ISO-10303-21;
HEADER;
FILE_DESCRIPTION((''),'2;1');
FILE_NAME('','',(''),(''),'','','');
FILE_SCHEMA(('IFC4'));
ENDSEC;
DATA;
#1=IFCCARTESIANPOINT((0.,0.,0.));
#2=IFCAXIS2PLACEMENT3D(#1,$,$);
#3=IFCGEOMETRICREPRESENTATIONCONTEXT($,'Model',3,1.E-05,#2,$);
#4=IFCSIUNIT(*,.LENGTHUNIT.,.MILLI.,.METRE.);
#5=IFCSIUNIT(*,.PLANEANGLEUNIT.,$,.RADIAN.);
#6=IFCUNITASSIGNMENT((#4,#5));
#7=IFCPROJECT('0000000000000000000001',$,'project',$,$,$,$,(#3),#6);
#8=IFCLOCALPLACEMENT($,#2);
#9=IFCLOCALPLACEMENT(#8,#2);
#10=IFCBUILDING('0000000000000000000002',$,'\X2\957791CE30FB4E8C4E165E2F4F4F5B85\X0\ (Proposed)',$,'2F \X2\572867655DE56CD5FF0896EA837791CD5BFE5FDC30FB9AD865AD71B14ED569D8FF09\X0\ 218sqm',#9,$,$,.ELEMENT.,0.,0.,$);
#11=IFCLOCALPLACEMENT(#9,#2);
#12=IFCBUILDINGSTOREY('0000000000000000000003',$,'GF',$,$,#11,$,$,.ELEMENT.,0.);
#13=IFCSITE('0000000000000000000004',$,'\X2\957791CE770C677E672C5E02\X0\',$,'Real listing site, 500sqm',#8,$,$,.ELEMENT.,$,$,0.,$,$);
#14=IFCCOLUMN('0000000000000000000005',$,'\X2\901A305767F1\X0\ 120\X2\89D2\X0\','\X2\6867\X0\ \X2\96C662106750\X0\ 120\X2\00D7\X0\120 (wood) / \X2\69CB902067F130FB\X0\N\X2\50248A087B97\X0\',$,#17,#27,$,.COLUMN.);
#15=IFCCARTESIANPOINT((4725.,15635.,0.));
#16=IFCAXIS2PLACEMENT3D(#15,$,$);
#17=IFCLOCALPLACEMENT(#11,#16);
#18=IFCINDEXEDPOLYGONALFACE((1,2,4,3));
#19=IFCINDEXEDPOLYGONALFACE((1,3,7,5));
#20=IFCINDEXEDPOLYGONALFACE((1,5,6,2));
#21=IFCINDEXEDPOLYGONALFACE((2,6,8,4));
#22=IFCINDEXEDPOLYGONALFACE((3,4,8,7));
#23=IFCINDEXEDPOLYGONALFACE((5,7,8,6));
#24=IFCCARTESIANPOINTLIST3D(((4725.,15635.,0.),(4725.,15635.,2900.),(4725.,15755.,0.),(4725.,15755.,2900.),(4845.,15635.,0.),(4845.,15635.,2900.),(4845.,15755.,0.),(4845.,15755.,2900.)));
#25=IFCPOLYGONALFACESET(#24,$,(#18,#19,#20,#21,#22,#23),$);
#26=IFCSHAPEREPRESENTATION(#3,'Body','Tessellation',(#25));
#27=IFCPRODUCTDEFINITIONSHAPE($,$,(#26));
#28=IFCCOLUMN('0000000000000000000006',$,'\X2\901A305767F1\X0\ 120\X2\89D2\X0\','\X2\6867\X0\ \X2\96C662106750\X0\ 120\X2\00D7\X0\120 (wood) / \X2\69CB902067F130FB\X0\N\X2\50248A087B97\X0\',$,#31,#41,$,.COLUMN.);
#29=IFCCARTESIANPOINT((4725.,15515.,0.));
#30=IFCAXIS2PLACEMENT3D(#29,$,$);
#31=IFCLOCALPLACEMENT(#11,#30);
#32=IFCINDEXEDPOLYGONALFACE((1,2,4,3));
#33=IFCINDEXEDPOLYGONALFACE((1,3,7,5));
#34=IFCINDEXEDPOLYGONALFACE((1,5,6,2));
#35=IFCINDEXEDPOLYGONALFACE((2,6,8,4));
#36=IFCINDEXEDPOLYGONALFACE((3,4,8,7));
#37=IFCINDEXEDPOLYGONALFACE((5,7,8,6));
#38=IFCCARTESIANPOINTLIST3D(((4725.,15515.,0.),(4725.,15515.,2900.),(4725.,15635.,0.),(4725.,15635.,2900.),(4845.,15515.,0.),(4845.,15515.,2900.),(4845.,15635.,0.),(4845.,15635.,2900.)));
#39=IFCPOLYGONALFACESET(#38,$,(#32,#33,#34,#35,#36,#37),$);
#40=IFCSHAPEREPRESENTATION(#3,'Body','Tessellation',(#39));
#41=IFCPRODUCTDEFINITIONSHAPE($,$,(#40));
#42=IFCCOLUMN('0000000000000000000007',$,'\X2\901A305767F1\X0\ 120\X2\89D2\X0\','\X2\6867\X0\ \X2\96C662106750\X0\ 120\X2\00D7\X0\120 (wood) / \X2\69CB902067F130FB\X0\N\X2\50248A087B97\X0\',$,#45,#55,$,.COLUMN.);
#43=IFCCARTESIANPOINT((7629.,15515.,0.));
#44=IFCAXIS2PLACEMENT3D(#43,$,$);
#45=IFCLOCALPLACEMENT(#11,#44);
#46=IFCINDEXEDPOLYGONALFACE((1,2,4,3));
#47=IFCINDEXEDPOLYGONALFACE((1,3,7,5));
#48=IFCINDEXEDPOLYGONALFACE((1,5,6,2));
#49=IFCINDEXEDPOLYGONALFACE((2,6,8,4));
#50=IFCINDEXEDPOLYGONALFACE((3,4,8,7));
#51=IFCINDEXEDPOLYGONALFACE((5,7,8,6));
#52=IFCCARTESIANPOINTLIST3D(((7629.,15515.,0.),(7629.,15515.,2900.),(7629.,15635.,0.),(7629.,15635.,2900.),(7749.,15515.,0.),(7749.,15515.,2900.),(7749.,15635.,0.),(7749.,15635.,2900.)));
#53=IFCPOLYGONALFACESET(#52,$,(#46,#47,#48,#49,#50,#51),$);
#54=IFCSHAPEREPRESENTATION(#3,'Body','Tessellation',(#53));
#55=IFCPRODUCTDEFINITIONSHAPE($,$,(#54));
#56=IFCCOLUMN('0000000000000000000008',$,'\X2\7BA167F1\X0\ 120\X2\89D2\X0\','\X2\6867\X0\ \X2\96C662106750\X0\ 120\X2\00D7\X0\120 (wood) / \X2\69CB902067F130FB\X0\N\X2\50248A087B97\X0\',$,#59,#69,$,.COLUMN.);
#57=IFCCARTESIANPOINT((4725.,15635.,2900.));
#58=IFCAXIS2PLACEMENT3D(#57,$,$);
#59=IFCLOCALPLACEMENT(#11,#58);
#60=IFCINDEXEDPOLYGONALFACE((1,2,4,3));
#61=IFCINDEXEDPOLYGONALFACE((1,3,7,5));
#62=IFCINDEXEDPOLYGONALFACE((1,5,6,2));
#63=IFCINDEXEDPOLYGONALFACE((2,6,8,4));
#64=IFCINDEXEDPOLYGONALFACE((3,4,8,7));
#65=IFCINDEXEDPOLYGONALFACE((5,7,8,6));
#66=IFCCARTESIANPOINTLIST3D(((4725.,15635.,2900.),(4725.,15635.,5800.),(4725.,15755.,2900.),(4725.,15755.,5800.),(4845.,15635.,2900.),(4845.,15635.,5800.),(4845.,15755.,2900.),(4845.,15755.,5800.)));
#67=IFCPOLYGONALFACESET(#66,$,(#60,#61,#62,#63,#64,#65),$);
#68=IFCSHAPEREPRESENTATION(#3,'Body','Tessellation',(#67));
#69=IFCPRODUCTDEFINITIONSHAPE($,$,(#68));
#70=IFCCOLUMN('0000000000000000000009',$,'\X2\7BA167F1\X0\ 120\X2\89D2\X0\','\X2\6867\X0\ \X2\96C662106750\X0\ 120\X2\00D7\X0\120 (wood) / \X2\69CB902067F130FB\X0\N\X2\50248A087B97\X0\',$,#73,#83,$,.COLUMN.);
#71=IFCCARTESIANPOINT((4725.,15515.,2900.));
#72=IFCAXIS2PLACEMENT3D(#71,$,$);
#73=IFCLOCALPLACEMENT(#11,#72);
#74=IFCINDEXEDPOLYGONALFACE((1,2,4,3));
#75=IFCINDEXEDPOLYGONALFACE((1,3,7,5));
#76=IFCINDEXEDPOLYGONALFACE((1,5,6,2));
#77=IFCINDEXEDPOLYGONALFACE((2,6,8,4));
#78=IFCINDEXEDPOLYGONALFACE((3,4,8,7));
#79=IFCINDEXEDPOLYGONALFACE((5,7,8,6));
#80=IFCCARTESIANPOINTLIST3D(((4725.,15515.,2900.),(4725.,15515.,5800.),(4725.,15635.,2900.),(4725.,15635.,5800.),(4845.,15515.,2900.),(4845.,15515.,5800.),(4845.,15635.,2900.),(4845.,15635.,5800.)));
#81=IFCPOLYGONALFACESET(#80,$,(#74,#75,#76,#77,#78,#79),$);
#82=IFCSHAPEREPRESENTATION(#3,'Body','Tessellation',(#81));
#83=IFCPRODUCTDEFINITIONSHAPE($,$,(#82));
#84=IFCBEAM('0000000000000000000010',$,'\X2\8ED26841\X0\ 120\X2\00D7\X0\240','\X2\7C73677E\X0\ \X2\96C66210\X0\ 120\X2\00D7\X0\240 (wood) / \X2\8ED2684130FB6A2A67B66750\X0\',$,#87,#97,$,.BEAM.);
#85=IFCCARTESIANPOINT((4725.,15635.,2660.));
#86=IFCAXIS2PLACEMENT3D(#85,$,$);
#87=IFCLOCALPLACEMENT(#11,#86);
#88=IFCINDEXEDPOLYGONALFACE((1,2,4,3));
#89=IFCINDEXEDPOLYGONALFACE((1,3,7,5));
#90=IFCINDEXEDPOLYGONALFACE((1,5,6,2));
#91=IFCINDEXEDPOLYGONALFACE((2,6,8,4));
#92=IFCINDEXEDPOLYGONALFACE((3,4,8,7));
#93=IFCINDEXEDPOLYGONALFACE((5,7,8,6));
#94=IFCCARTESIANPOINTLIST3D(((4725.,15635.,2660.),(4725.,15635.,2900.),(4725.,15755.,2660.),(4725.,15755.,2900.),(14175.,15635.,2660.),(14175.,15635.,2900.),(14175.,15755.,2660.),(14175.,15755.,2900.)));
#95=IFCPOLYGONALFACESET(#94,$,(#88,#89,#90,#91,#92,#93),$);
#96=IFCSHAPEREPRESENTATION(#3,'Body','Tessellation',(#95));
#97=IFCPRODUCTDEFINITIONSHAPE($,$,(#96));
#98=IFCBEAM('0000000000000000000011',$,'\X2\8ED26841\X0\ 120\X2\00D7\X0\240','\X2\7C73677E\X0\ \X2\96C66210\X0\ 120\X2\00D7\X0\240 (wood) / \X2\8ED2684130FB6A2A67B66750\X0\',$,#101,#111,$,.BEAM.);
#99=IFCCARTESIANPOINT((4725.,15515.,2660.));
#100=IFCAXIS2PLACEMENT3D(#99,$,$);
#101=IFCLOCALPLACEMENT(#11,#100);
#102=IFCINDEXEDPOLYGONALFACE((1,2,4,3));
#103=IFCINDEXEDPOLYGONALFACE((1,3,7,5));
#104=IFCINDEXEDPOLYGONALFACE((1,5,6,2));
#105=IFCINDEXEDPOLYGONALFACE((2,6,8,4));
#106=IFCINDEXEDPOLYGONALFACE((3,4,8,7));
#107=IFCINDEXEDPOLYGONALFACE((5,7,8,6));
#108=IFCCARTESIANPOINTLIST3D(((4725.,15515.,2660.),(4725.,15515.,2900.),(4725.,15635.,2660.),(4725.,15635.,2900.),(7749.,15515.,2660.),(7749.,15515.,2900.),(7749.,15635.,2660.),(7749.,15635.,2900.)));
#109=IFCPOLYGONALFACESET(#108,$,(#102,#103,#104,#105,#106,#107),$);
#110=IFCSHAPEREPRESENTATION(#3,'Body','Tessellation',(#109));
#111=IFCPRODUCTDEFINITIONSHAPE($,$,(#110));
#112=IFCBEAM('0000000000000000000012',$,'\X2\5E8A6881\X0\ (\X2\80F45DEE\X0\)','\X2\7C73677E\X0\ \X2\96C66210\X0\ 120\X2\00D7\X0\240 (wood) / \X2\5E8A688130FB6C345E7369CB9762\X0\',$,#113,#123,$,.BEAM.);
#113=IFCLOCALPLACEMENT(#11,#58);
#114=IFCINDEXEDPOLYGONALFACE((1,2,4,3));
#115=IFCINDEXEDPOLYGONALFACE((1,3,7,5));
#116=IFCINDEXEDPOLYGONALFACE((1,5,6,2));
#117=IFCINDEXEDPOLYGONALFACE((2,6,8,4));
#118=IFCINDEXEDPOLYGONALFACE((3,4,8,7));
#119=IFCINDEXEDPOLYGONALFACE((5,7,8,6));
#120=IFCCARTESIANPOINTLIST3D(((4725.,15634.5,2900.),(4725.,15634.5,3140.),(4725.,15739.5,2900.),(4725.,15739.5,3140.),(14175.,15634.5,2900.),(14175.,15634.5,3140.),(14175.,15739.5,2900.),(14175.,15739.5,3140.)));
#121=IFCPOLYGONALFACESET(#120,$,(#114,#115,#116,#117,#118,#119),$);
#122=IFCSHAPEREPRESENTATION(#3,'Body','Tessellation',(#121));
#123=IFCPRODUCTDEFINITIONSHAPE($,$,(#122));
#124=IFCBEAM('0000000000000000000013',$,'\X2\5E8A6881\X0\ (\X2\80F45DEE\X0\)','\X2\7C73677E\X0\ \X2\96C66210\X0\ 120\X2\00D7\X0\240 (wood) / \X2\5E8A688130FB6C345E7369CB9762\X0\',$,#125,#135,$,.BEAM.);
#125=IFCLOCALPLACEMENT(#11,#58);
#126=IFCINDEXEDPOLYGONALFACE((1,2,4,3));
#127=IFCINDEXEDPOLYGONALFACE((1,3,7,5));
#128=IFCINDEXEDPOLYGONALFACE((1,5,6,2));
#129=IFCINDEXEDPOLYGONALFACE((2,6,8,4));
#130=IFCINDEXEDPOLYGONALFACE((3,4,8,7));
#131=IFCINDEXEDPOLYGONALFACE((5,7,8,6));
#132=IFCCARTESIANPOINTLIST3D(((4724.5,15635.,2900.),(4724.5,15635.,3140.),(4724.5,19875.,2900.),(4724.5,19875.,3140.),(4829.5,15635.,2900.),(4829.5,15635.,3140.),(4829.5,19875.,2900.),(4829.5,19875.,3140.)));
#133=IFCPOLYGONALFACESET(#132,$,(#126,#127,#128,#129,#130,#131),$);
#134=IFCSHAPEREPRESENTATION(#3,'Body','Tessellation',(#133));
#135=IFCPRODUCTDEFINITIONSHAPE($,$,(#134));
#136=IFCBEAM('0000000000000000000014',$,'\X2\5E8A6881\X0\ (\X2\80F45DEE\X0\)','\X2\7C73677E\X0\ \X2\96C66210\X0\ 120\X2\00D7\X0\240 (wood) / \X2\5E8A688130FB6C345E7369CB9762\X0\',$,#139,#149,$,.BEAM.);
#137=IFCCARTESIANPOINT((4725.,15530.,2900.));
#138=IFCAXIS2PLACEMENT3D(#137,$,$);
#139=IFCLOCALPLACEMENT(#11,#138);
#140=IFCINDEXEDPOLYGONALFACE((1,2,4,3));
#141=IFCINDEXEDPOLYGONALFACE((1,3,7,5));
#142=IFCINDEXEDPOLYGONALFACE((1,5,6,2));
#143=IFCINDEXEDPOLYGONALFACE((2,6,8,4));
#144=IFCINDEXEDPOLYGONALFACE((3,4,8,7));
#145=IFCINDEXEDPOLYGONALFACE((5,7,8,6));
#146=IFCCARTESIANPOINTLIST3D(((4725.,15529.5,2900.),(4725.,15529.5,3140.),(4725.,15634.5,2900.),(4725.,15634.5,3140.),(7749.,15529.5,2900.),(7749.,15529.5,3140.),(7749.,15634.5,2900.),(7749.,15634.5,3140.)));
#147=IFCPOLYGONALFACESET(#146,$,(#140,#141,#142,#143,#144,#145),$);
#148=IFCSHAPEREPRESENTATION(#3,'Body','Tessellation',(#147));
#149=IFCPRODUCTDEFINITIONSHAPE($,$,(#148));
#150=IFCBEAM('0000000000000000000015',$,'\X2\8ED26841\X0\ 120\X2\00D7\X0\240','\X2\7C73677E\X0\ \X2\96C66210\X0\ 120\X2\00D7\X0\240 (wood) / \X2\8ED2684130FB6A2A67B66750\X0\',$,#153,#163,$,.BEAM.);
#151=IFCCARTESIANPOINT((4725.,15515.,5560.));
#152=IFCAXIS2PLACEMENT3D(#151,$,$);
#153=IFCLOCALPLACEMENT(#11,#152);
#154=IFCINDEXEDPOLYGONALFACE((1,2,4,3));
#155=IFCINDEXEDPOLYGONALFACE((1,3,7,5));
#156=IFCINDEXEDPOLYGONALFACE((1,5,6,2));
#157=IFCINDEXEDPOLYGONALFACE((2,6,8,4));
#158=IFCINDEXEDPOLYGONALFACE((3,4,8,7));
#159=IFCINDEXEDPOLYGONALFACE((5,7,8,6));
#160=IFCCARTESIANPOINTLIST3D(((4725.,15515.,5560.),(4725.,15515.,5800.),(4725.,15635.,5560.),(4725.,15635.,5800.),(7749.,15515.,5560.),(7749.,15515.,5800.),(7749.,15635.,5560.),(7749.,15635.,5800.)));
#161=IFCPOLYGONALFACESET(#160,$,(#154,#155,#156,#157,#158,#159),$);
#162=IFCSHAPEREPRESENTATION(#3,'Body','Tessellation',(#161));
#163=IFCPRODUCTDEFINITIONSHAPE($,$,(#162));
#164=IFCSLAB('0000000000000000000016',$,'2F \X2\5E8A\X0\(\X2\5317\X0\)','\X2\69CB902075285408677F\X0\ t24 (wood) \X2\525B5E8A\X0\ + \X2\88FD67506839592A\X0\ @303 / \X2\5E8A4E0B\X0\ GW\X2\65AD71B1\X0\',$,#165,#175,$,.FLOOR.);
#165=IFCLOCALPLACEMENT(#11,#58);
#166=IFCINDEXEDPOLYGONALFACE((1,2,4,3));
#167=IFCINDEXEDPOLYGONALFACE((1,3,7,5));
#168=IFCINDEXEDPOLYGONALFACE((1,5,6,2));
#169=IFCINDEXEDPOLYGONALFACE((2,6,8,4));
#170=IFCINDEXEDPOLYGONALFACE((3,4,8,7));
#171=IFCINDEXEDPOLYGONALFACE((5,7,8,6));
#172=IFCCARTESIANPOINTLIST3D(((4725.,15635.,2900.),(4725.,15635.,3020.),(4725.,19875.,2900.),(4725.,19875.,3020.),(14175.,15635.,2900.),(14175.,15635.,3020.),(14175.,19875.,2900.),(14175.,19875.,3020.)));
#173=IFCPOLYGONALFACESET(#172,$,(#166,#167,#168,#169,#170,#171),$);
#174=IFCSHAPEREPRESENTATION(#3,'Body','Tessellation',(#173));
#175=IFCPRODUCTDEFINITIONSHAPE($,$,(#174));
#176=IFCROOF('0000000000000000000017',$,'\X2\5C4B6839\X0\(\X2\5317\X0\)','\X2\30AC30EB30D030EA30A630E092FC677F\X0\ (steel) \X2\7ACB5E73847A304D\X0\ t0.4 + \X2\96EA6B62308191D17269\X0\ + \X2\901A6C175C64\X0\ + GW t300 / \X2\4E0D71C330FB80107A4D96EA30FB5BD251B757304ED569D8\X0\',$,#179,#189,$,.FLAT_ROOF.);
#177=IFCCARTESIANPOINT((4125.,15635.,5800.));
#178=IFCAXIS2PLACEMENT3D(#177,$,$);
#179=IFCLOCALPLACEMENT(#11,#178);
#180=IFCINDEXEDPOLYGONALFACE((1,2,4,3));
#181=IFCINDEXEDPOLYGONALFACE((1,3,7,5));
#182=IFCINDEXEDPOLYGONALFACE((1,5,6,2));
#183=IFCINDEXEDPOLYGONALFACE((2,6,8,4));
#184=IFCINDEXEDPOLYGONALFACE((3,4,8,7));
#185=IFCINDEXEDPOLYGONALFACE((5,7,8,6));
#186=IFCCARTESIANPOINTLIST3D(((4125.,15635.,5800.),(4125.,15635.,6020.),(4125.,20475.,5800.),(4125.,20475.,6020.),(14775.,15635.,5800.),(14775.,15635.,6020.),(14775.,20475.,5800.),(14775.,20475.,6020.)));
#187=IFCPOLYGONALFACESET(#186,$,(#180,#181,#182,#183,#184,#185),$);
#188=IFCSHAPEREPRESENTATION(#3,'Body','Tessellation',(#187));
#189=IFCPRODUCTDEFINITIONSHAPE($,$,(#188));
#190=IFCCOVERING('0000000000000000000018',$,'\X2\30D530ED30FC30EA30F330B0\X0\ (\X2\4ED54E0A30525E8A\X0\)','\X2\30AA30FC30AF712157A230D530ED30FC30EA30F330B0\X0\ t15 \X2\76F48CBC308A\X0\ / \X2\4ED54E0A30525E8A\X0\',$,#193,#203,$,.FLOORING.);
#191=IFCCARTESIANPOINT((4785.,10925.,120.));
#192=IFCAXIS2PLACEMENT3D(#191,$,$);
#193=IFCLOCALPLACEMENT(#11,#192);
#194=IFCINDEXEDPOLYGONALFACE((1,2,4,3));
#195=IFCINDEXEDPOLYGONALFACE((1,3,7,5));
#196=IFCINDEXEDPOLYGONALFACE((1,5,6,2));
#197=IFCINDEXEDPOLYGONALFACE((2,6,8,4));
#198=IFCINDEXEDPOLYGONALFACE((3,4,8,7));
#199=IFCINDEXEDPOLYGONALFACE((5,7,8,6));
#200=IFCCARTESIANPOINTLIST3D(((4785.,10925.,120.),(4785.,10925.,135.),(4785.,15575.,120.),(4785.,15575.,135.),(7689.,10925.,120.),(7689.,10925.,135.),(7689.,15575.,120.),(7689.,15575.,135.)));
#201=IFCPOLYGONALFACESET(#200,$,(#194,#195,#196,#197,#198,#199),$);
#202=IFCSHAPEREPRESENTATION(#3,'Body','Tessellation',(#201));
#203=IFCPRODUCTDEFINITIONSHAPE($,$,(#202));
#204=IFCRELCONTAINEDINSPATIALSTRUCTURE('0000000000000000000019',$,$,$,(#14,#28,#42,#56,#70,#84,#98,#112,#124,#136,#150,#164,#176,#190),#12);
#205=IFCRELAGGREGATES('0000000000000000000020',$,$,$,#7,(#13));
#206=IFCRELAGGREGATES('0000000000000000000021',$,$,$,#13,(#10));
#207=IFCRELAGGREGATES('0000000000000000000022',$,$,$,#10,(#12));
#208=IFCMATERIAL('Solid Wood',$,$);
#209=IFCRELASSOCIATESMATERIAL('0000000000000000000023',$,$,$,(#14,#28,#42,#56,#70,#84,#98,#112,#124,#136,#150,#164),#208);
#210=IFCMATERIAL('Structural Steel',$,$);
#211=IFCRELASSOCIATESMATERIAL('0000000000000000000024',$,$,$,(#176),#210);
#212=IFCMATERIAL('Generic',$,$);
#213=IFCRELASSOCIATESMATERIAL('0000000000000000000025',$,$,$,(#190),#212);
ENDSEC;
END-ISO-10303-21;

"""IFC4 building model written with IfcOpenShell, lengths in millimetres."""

from ifc_helpers import new_model, si_unit, frame, frame_2d, origin, place, context, project, spatial, rectangle, extrude, material, element, save


model = new_model("IFC4")

# Units and contexts
model_context = context("Model", 3, precision=1e-05, world=origin())
ifc_project = project(units=[si_unit("LENGTHUNIT", "METRE", prefix="MILLI"), si_unit("PLANEANGLEUNIT", "RADIAN")], contexts=[model_context])

# Site, building, storey
site_placement = place(None, origin())
site = spatial("IfcSite", under=ifc_project, at=site_placement, Name="長野県松本市", ObjectType="Real listing site, 500sqm", CompositionType="ELEMENT", RefElevation=0.0)
building_placement = place(site_placement, origin())
building = spatial("IfcBuilding", under=site, at=building_placement, Name="長野・二世帯住宅 (Proposed)", ObjectType="2F 在来工法（雪荷重対応・高断熱仕様） 218sqm", CompositionType="ELEMENT", ElevationOfRefHeight=0.0, ElevationOfTerrain=0.0)
storey_placement = place(building_placement, origin())
storey = spatial("IfcBuildingStorey", under=building, at=storey_placement, Name="GF", CompositionType="ELEMENT", Elevation=0.0)

# Columns
ifc_material_1 = material(Name="Solid Wood")
column_1_placement = place(storey_placement, frame((4725.0, 15635.0, 0.0)))
element("IfcColumn", 1, at=column_1_placement, inside=storey, material=ifc_material_1, Name="通し柱 120角", Description="桧 集成材 120×120 (wood) / 構造柱・N値計算", PredefinedType="COLUMN", context=model_context, shape_type="SweptSolid", body=[
    extrude(rectangle(XDim=120.0, YDim=120.0, at=frame_2d((60.0, 60.0))), frame((4725.0, 15635.0, 0.0)), (0.0, 0.0, 1.0), 2900.0),
])
column_2_placement = place(storey_placement, frame((4725.0, 15515.0, 0.0)))
element("IfcColumn", 2, at=column_2_placement, inside=storey, material=ifc_material_1, Name="通し柱 120角", Description="桧 集成材 120×120 (wood) / 構造柱・N値計算", PredefinedType="COLUMN", context=model_context, shape_type="SweptSolid", body=[
    extrude(rectangle(XDim=120.0, YDim=120.0, at=frame_2d((60.0, 60.0))), frame((4725.0, 15515.0, 0.0)), (0.0, 0.0, 1.0), 2900.0),
])
column_3_placement = place(storey_placement, frame((7629.0, 15515.0, 0.0)))
element("IfcColumn", 3, at=column_3_placement, inside=storey, material=ifc_material_1, Name="通し柱 120角", Description="桧 集成材 120×120 (wood) / 構造柱・N値計算", PredefinedType="COLUMN", context=model_context, shape_type="SweptSolid", body=[
    extrude(rectangle(XDim=120.0, YDim=120.0, at=frame_2d((60.0, 60.0))), frame((7629.0, 15515.0, 0.0)), (0.0, 0.0, 1.0), 2900.0),
])
column_4_placement = place(storey_placement, frame((4725.0, 15635.0, 2900.0)))
element("IfcColumn", 4, at=column_4_placement, inside=storey, material=ifc_material_1, Name="管柱 120角", Description="桧 集成材 120×120 (wood) / 構造柱・N値計算", PredefinedType="COLUMN", context=model_context, shape_type="SweptSolid", body=[
    extrude(rectangle(XDim=120.0, YDim=120.0, at=frame_2d((60.0, 60.0))), frame((4725.0, 15635.0, 2900.0)), (0.0, 0.0, 1.0), 2900.0),
])
column_5_placement = place(storey_placement, frame((4725.0, 15515.0, 2900.0)))
element("IfcColumn", 5, at=column_5_placement, inside=storey, material=ifc_material_1, Name="管柱 120角", Description="桧 集成材 120×120 (wood) / 構造柱・N値計算", PredefinedType="COLUMN", context=model_context, shape_type="SweptSolid", body=[
    extrude(rectangle(XDim=120.0, YDim=120.0, at=frame_2d((60.0, 60.0))), frame((4725.0, 15515.0, 2900.0)), (0.0, 0.0, 1.0), 2900.0),
])

# Beams
beam_1_placement = place(storey_placement, frame((4725.0, 15635.0, 2660.0)))
element("IfcBeam", 6, at=beam_1_placement, inside=storey, material=ifc_material_1, Name="軒桁 120×240", Description="米松 集成 120×240 (wood) / 軒桁・横架材", PredefinedType="BEAM", context=model_context, shape_type="SweptSolid", body=[
    extrude(rectangle(XDim=9450.0, YDim=120.0, at=frame_2d((4725.0, 60.0))), frame((4725.0, 15635.0, 2660.0)), (0.0, 0.0, 1.0), 240.0),
])
beam_2_placement = place(storey_placement, frame((4725.0, 15515.0, 2660.0)))
element("IfcBeam", 7, at=beam_2_placement, inside=storey, material=ifc_material_1, Name="軒桁 120×240", Description="米松 集成 120×240 (wood) / 軒桁・横架材", PredefinedType="BEAM", context=model_context, shape_type="SweptSolid", body=[
    extrude(rectangle(XDim=3024.0, YDim=120.0, at=frame_2d((1512.0, 60.0))), frame((4725.0, 15515.0, 2660.0)), (0.0, 0.0, 1.0), 240.0),
])
beam_3_placement = place(storey_placement, frame((4725.0, 15635.0, 2900.0)))
element("IfcBeam", 8, at=beam_3_placement, inside=storey, material=ifc_material_1, Name="床梁 (胴差)", Description="米松 集成 120×240 (wood) / 床梁・水平構面", PredefinedType="BEAM", context=model_context, shape_type="SweptSolid", body=[
    extrude(rectangle(XDim=9450.0, YDim=105.0, at=frame_2d((4725.0, 52.0))), frame((4725.0, 15635.0, 2900.0)), (0.0, 0.0, 1.0), 240.0),
])
beam_4_placement = place(storey_placement, frame((4725.0, 15635.0, 2900.0)))
element("IfcBeam", 9, at=beam_4_placement, inside=storey, material=ifc_material_1, Name="床梁 (胴差)", Description="米松 集成 120×240 (wood) / 床梁・水平構面", PredefinedType="BEAM", context=model_context, shape_type="SweptSolid", body=[
    extrude(rectangle(XDim=105.0, YDim=4240.0, at=frame_2d((52.0, 2120.0))), frame((4725.0, 15635.0, 2900.0)), (0.0, 0.0, 1.0), 240.0),
])
beam_5_placement = place(storey_placement, frame((4725.0, 15530.0, 2900.0)))
element("IfcBeam", 10, at=beam_5_placement, inside=storey, material=ifc_material_1, Name="床梁 (胴差)", Description="米松 集成 120×240 (wood) / 床梁・水平構面", PredefinedType="BEAM", context=model_context, shape_type="SweptSolid", body=[
    extrude(rectangle(XDim=3024.0, YDim=105.0, at=frame_2d((1512.0, 52.0))), frame((4725.0, 15530.0, 2900.0)), (0.0, 0.0, 1.0), 240.0),
])
beam_6_placement = place(storey_placement, frame((4725.0, 15515.0, 5560.0)))
element("IfcBeam", 11, at=beam_6_placement, inside=storey, material=ifc_material_1, Name="軒桁 120×240", Description="米松 集成 120×240 (wood) / 軒桁・横架材", PredefinedType="BEAM", context=model_context, shape_type="SweptSolid", body=[
    extrude(rectangle(XDim=3024.0, YDim=120.0, at=frame_2d((1512.0, 60.0))), frame((4725.0, 15515.0, 5560.0)), (0.0, 0.0, 1.0), 240.0),
])

# Slab
slab_1_placement = place(storey_placement, frame((4725.0, 15635.0, 2900.0)))
element("IfcSlab", 12, at=slab_1_placement, inside=storey, material=ifc_material_1, Name="2F 床(北)", Description="構造用合板 t24 (wood) 剛床 + 製材根太 @303 / 床下 GW断熱", PredefinedType="FLOOR", context=model_context, shape_type="SweptSolid", body=[
    extrude(rectangle(XDim=9450.0, YDim=4240.0, at=frame_2d((4725.0, 2120.0))), frame((4725.0, 15635.0, 2900.0)), (0.0, 0.0, 1.0), 120.0),
])

# Roof
ifc_material_2 = material(Name="Structural Steel")
for number, where, name in (
    (13, (4125.0, 15635.0, 5800.0), "屋根(北)"),
):
    element("IfcRoof", number, at=place(storey_placement, frame(where)), inside=storey, material=ifc_material_2, Name=name, Description="ガルバリウム鋼板 (steel) 立平葺き t0.4 + 雪止め金物 + 通気層 + GW t300 / 不燃・耐積雪・寒冷地仕様", PredefinedType="FLAT_ROOF", context=model_context, shape_type="SweptSolid", body=[
        extrude(rectangle(XDim=10650.0, YDim=4840.0, at=frame_2d((5325.0, 2420.0))), frame((4125.0, 15635.0, 5800.0)), (0.0, 0.0, 1.0), 220.0),
    ])

# Covering
ifc_material_3 = material(Name="Generic")
covering_1_placement = place(storey_placement, frame((4785.0, 10925.0, 120.0)))
element("IfcCovering", 14, at=covering_1_placement, inside=storey, material=ifc_material_3, Name="フローリング (仕上げ床)", Description="オーク無垢フローリング t15 直貼り / 仕上げ床", PredefinedType="FLOORING", context=model_context, shape_type="SweptSolid", body=[
    extrude(rectangle(XDim=2904.0, YDim=4650.0, at=frame_2d((1452.0, 2325.0))), frame((4785.0, 10925.0, 120.0)), (0.0, 0.0, 1.0), 15.0),
])

save(model, "model.ifc")
